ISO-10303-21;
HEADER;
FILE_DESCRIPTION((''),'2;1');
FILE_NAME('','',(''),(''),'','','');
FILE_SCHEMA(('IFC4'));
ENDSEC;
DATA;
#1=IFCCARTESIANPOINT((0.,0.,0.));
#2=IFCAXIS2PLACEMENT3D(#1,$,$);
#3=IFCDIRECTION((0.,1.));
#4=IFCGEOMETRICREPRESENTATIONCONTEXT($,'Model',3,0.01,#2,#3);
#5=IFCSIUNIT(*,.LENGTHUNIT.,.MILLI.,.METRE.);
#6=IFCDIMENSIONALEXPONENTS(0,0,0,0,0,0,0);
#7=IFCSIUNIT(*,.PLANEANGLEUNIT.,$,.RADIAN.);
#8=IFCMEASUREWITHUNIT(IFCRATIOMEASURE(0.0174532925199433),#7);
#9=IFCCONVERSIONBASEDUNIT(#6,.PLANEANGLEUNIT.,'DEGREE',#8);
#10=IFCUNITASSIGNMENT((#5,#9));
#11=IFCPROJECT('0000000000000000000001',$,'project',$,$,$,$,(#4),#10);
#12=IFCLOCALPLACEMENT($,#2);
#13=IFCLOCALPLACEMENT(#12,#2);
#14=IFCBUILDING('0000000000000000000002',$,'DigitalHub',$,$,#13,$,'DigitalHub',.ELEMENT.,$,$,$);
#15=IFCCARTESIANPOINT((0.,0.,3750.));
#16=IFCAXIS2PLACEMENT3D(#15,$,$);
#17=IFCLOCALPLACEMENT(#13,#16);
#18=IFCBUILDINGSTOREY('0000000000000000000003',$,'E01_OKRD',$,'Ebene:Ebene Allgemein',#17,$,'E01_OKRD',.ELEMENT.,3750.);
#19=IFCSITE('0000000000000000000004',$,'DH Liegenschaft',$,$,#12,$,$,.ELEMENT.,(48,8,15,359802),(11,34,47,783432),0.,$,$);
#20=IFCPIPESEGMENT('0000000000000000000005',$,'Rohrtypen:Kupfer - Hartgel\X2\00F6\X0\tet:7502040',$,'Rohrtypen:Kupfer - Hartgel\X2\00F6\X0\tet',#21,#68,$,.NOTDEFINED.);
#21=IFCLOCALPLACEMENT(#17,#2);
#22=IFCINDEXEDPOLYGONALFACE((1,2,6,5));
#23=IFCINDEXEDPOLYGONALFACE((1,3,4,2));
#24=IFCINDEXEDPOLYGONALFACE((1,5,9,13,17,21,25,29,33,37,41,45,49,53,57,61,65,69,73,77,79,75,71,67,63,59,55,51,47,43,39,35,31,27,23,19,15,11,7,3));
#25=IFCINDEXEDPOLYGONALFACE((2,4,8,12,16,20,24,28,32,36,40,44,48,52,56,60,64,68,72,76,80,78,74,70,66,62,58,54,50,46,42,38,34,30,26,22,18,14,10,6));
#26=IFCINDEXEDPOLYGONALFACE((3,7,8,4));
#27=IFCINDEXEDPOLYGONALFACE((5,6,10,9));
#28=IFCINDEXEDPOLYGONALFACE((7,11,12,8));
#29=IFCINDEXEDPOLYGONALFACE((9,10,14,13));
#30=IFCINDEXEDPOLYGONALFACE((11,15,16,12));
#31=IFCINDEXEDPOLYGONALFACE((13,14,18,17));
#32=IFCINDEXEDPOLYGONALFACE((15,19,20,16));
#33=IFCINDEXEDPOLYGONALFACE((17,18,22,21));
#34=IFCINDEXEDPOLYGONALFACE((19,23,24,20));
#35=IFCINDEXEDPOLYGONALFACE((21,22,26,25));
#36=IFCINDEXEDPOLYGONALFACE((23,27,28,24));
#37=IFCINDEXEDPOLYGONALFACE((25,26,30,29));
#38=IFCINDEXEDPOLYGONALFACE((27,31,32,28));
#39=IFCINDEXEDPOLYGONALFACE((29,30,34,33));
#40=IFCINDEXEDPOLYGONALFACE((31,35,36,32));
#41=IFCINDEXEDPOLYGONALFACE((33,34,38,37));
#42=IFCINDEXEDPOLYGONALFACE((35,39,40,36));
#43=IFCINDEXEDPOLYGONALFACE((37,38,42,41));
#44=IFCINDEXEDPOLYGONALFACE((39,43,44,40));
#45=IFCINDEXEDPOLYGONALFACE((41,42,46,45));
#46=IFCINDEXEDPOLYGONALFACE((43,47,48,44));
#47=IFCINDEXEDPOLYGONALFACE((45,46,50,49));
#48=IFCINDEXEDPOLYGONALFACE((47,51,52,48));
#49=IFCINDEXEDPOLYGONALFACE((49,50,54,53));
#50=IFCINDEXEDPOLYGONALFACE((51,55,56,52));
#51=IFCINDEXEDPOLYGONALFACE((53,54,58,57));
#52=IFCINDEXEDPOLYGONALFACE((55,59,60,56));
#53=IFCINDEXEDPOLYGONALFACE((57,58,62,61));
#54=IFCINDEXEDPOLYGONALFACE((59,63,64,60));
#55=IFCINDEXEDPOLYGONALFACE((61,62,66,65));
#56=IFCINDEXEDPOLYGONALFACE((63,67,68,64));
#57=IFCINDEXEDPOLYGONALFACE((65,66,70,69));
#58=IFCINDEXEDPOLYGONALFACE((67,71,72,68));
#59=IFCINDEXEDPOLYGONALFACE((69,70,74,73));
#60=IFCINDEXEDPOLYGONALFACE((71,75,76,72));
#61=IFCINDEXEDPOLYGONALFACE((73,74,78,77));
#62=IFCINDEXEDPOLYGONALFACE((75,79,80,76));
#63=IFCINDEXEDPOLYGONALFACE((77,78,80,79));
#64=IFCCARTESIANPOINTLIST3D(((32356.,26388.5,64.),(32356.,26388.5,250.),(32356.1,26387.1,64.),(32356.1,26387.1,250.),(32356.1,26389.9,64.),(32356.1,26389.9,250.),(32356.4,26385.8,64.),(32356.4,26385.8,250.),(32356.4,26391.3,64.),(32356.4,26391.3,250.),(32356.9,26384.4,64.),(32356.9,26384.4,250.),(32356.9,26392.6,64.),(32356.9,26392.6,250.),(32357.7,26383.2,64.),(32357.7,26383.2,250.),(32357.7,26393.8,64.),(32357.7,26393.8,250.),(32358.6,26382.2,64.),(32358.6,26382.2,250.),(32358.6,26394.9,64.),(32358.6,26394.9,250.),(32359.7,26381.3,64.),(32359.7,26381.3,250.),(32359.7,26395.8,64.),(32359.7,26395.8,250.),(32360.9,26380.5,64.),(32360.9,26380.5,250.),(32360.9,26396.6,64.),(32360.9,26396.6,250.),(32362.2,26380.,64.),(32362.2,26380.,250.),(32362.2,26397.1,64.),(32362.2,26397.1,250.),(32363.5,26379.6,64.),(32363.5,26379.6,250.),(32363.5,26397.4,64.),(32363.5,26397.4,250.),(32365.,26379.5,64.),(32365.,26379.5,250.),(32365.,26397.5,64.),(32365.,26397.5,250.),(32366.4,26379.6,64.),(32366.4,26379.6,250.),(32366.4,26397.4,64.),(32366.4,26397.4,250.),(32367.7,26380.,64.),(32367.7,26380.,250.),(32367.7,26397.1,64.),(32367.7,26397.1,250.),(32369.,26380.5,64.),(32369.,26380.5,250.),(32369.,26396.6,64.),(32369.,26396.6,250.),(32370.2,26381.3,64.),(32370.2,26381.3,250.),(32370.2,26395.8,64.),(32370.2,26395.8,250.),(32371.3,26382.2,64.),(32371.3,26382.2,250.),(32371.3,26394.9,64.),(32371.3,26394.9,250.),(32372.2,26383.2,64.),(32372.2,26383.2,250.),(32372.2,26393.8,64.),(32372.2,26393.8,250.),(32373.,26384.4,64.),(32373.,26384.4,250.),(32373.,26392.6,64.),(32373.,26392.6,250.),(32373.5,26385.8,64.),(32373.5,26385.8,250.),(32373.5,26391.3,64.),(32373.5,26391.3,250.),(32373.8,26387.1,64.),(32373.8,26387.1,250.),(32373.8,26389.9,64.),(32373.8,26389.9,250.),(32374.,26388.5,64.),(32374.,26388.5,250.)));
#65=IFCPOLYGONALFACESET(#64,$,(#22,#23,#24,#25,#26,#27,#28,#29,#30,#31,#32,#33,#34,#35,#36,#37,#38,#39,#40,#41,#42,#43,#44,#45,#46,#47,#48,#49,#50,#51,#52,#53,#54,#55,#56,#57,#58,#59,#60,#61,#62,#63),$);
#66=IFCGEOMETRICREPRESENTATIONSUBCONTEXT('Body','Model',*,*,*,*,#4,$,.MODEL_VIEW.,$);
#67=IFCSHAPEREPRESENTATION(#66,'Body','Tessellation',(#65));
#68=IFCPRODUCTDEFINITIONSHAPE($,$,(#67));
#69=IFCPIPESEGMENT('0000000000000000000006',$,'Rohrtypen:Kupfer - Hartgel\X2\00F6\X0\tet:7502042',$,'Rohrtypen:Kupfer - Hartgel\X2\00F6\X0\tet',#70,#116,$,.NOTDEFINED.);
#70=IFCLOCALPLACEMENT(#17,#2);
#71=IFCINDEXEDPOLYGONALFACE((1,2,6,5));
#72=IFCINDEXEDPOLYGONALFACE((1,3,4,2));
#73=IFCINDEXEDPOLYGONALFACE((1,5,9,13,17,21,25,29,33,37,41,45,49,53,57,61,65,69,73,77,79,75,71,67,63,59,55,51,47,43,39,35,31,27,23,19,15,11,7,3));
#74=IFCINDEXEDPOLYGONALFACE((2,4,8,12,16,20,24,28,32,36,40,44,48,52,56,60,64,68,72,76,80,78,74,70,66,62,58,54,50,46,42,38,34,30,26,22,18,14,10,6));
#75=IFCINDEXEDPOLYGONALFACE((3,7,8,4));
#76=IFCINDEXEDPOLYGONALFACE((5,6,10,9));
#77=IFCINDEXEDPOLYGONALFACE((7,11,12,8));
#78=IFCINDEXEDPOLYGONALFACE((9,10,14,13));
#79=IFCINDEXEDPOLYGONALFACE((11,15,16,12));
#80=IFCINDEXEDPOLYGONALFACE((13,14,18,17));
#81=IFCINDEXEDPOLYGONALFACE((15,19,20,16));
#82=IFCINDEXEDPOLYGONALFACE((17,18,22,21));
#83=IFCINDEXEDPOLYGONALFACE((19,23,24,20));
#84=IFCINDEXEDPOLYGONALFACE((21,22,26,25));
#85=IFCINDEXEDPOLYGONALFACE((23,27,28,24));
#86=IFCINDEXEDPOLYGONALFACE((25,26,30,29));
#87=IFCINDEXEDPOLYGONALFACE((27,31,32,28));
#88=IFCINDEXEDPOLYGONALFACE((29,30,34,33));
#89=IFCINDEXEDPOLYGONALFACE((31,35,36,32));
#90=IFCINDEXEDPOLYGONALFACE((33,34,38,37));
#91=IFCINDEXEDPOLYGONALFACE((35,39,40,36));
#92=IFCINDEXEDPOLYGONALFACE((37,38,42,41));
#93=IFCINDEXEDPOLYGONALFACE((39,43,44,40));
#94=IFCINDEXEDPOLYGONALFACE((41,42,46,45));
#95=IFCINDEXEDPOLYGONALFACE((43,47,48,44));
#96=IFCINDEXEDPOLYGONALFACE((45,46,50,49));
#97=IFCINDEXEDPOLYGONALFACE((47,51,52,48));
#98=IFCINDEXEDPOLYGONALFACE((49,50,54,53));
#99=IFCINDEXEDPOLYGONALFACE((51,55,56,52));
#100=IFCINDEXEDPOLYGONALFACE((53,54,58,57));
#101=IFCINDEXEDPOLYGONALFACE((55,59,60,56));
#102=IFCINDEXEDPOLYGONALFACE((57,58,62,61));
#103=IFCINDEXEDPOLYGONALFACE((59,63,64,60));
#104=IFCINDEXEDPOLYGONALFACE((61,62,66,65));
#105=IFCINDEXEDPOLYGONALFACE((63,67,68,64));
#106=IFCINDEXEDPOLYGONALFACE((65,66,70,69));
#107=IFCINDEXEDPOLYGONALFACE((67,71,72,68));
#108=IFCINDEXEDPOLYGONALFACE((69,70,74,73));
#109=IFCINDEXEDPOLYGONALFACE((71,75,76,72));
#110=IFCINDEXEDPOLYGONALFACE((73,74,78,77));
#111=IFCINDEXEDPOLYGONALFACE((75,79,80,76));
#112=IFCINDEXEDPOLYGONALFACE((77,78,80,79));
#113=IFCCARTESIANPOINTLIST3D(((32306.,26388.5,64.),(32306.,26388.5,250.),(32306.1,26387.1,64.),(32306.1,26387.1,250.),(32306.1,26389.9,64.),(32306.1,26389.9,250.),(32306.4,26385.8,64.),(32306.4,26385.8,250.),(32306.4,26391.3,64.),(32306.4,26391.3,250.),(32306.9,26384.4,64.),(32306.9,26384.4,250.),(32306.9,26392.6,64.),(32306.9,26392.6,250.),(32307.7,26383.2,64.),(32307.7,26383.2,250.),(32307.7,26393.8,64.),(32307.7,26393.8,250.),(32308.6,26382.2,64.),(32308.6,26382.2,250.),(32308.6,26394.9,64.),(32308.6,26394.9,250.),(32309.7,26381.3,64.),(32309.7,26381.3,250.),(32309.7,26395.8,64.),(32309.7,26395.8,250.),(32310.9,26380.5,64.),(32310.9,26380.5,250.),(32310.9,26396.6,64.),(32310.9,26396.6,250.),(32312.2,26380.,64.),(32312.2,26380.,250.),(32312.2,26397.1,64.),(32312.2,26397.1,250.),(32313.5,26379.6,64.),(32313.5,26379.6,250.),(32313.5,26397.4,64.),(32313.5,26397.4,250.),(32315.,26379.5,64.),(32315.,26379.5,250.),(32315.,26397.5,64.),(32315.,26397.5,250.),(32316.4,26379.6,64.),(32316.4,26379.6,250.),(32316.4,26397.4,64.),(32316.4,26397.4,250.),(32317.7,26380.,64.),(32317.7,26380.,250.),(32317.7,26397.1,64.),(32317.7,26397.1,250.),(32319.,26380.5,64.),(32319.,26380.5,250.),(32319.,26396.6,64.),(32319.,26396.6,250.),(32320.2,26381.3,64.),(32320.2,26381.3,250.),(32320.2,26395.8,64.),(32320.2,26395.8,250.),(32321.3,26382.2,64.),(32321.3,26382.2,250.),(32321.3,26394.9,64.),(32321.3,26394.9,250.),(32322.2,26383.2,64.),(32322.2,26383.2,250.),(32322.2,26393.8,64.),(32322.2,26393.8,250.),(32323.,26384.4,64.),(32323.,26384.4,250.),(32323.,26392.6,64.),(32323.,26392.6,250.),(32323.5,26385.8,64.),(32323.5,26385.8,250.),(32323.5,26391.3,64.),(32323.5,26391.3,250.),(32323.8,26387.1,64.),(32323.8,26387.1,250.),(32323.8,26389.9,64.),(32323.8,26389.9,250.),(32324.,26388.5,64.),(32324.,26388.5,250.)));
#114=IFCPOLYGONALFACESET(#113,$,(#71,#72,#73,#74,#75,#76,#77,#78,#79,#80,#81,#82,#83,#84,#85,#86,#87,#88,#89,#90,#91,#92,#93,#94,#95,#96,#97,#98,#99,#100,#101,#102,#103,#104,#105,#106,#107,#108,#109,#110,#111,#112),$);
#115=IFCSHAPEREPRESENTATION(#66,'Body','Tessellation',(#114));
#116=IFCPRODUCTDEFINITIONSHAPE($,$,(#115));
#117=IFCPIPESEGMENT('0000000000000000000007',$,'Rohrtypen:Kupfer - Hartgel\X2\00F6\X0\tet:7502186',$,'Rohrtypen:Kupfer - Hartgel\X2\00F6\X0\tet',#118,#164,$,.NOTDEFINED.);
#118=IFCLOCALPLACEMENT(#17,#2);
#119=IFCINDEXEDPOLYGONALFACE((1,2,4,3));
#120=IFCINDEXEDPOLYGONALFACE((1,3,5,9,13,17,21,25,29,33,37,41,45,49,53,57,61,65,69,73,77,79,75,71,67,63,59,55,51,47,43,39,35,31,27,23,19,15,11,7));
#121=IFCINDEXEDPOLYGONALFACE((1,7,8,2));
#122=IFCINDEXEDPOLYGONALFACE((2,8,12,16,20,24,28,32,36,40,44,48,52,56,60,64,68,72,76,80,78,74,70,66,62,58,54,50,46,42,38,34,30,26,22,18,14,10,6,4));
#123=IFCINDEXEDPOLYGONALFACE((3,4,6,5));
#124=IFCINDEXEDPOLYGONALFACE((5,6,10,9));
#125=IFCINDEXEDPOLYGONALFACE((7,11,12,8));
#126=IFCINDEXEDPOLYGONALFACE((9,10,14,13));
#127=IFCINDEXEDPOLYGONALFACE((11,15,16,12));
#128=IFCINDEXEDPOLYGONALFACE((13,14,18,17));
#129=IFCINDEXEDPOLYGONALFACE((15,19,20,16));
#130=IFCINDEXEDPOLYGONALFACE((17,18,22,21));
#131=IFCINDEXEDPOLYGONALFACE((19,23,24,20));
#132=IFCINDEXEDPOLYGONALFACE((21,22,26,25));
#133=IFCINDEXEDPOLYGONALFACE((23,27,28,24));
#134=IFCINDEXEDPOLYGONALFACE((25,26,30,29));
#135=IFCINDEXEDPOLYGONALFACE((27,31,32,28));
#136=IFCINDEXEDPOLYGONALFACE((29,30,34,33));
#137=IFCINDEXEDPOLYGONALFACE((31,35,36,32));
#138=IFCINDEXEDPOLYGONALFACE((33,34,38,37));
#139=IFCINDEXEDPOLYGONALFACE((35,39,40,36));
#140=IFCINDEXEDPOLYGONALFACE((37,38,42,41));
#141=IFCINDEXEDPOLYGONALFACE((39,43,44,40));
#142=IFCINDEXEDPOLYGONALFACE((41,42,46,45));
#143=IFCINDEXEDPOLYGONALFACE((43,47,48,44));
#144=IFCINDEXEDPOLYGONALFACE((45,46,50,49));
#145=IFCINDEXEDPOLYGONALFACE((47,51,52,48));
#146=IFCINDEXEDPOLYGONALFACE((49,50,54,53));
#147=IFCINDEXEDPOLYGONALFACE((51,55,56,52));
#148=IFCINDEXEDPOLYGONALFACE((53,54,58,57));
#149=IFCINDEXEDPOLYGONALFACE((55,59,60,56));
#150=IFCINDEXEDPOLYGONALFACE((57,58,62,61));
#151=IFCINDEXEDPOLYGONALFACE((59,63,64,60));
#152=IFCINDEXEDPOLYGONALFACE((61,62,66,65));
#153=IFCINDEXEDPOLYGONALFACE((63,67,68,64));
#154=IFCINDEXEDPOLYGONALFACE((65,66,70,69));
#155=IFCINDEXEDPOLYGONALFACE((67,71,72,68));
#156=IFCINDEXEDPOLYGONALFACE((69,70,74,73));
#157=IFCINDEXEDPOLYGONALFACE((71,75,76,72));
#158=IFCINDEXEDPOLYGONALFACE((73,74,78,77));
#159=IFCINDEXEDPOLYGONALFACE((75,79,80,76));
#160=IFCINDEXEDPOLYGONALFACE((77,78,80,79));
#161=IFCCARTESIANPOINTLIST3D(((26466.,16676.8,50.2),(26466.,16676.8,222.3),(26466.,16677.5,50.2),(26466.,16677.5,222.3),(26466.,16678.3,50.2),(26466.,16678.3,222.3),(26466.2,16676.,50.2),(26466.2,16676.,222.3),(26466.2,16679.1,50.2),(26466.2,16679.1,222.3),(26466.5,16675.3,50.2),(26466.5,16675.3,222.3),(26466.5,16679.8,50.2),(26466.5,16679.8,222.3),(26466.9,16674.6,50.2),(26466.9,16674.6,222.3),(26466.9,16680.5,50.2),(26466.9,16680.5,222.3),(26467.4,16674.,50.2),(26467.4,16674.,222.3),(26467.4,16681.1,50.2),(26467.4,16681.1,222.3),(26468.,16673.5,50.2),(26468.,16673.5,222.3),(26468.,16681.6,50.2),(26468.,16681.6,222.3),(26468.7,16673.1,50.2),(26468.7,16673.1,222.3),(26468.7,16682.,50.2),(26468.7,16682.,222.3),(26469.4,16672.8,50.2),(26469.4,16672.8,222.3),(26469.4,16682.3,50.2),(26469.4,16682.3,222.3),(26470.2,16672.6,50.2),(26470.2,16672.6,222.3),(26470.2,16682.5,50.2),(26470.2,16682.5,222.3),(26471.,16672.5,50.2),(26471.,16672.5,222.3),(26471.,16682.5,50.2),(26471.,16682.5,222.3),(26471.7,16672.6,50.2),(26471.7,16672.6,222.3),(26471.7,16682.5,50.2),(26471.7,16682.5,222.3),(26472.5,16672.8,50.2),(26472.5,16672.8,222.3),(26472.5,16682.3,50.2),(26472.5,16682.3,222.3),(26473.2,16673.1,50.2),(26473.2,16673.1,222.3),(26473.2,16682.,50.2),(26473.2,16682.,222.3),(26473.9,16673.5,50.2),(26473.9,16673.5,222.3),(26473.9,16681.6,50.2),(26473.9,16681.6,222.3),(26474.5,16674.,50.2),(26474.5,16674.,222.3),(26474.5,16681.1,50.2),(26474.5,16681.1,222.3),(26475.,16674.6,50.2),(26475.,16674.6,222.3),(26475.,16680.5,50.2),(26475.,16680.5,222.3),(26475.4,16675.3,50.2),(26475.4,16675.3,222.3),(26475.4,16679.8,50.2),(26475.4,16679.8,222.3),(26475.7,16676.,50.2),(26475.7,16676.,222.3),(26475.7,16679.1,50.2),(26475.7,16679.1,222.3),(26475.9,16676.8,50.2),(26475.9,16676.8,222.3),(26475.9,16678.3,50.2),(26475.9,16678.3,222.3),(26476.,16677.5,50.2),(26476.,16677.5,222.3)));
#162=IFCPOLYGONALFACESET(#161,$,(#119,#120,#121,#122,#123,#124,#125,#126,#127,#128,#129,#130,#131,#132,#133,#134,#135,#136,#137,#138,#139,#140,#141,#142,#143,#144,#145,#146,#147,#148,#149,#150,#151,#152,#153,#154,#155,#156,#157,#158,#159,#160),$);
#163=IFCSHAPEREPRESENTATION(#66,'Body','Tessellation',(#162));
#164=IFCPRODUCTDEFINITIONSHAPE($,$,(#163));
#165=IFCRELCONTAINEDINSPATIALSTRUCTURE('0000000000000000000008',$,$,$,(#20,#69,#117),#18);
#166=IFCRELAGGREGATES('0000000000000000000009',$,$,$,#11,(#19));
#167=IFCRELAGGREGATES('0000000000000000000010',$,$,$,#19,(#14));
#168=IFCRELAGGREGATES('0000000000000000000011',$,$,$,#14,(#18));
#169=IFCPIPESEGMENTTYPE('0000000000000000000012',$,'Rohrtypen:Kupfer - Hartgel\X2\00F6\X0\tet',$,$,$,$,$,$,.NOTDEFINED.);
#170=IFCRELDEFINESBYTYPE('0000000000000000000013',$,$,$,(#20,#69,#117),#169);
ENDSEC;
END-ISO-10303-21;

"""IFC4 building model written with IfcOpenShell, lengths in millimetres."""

from ifc_helpers import new_model, entity, si_unit, converted_unit, direction, frame, origin, place, context, subcontext, project, spatial, indexed_curve, outline, extrude, type_object, element, save


model = new_model("IFC4")

# Units and contexts
model_context = context("Model", 3, precision=0.01, world=origin(), true_north=direction((0.0, 1.0)))
body_context = subcontext(model_context, "Body", "Model", "MODEL_VIEW")
ifc_project = project(units=[si_unit("LENGTHUNIT", "METRE", prefix="MILLI"), converted_unit("PLANEANGLEUNIT", "DEGREE", entity("IfcRatioMeasure", 0.0174532925199433), si_unit("PLANEANGLEUNIT", "RADIAN"), dimensions=[0, 0, 0, 0, 0, 0, 0])], contexts=[model_context])

# Site, building, storey
site_placement = place(None, origin())
site = spatial("IfcSite", under=ifc_project, at=site_placement, Name="DH Liegenschaft", CompositionType="ELEMENT", RefLatitude=(48, 8, 15, 359802), RefLongitude=(11, 34, 47, 783432), RefElevation=0.0)
building_placement = place(site_placement, origin())
building = spatial("IfcBuilding", under=site, at=building_placement, Name="DigitalHub", LongName="DigitalHub", CompositionType="ELEMENT")
storey_placement = place(building_placement, frame((0.0, 0.0, 3750.0)))
storey = spatial("IfcBuildingStorey", under=building, at=storey_placement, Name="E01_OKRD", ObjectType="Ebene:Ebene Allgemein", LongName="E01_OKRD", CompositionType="ELEMENT", Elevation=3750.0)

# Pipe segments
pipe_segment_type = type_object("IfcPipeSegmentType", Name="Rohrtypen:Kupfer - Hartgelötet", PredefinedType="NOTDEFINED")
pipe_segment_1_placement = place(storey_placement, frame((32354.4, 26377.9, 64.0)))
element("IfcPipeSegment", 1, at=pipe_segment_1_placement, inside=storey, type_object=pipe_segment_type, Name="Rohrtypen:Kupfer - Hartgelötet:7502040", ObjectType="Rohrtypen:Kupfer - Hartgelötet", PredefinedType="NOTDEFINED", context=body_context, shape_type="SweptSolid", body=[
    extrude(outline(indexed_curve([(9.0, 0.0), (8.9, 1.4), (8.6, 2.8), (8.0, 4.1), (7.3, 5.3), (6.4, 6.4), (5.3, 7.3), (4.1, 8.0), (2.8, 8.6), (1.4, 8.9), (0.0, 9.0), (-1.4, 8.9), (-2.8, 8.6), (-4.1, 8.0), (-5.3, 7.3), (-6.4, 6.4), (-7.3, 5.3), (-8.0, 4.1), (-8.6, 2.8), (-8.9, 1.4), (-9.0, 0.0), (-8.9, -1.4), (-8.6, -2.8), (-8.0, -4.1), (-7.3, -5.3), (-6.4, -6.4), (-5.3, -7.3), (-4.1, -8.0), (-2.8, -8.6), (-1.4, -8.9), (0.0, -9.0), (1.4, -8.9), (2.8, -8.6), (4.1, -8.0), (5.3, -7.3), (6.4, -6.4), (7.3, -5.3), (8.0, -4.1), (8.6, -2.8), (8.9, -1.4), (9.0, 0.0)], self_intersect=False)), frame((10.6, 10.6, 0.0)), (0.0, 0.0, 1.0), 186.0),
])
pipe_segment_2_placement = place(storey_placement, frame((32304.4, 26377.9, 64.0)))
element("IfcPipeSegment", 2, at=pipe_segment_2_placement, inside=storey, type_object=pipe_segment_type, Name="Rohrtypen:Kupfer - Hartgelötet:7502042", ObjectType="Rohrtypen:Kupfer - Hartgelötet", PredefinedType="NOTDEFINED", context=body_context, shape_type="SweptSolid", body=[
    extrude(outline(indexed_curve([(9.0, 0.0), (8.9, 1.4), (8.6, 2.8), (8.0, 4.1), (7.3, 5.3), (6.4, 6.4), (5.3, 7.3), (4.1, 8.0), (2.8, 8.6), (1.4, 8.9), (0.0, 9.0), (-1.4, 8.9), (-2.8, 8.6), (-4.1, 8.0), (-5.3, 7.3), (-6.4, 6.4), (-7.3, 5.3), (-8.0, 4.1), (-8.6, 2.8), (-8.9, 1.4), (-9.0, 0.0), (-8.9, -1.4), (-8.6, -2.8), (-8.0, -4.1), (-7.3, -5.3), (-6.4, -6.4), (-5.3, -7.3), (-4.1, -8.0), (-2.8, -8.6), (-1.4, -8.9), (0.0, -9.0), (1.4, -8.9), (2.8, -8.6), (4.1, -8.0), (5.3, -7.3), (6.4, -6.4), (7.3, -5.3), (8.0, -4.1), (8.6, -2.8), (8.9, -1.4), (9.0, 0.0)], self_intersect=False)), frame((10.6, 10.6, 0.0)), (0.0, 0.0, 1.0), 186.0),
])
pipe_segment_3_placement = place(storey_placement, frame((26464.4, 16670.9, 50.2)))
element("IfcPipeSegment", 3, at=pipe_segment_3_placement, inside=storey, type_object=pipe_segment_type, Name="Rohrtypen:Kupfer - Hartgelötet:7502186", ObjectType="Rohrtypen:Kupfer - Hartgelötet", PredefinedType="NOTDEFINED", context=body_context, shape_type="SweptSolid", body=[
    extrude(outline(indexed_curve([(5.0, 0.0), (4.9, 0.8), (4.8, 1.5), (4.5, 2.3), (4.0, 2.9), (3.5, 3.5), (2.9, 4.0), (2.3, 4.5), (1.5, 4.8), (0.8, 4.9), (0.0, 5.0), (-0.8, 4.9), (-1.5, 4.8), (-2.3, 4.5), (-2.9, 4.0), (-3.5, 3.5), (-4.0, 2.9), (-4.5, 2.3), (-4.8, 1.5), (-4.9, 0.8), (-5.0, 0.0), (-4.9, -0.8), (-4.8, -1.5), (-4.5, -2.3), (-4.0, -2.9), (-3.5, -3.5), (-2.9, -4.0), (-2.3, -4.5), (-1.5, -4.8), (-0.8, -4.9), (0.0, -5.0), (0.8, -4.9), (1.5, -4.8), (2.3, -4.5), (2.9, -4.0), (3.5, -3.5), (4.0, -2.9), (4.5, -2.3), (4.8, -1.5), (4.9, -0.8), (5.0, 0.0)], self_intersect=False)), frame((6.6, 6.6, 0.0)), (0.0, 0.0, 1.0), 172.1),
])

save(model, "model.ifc")
